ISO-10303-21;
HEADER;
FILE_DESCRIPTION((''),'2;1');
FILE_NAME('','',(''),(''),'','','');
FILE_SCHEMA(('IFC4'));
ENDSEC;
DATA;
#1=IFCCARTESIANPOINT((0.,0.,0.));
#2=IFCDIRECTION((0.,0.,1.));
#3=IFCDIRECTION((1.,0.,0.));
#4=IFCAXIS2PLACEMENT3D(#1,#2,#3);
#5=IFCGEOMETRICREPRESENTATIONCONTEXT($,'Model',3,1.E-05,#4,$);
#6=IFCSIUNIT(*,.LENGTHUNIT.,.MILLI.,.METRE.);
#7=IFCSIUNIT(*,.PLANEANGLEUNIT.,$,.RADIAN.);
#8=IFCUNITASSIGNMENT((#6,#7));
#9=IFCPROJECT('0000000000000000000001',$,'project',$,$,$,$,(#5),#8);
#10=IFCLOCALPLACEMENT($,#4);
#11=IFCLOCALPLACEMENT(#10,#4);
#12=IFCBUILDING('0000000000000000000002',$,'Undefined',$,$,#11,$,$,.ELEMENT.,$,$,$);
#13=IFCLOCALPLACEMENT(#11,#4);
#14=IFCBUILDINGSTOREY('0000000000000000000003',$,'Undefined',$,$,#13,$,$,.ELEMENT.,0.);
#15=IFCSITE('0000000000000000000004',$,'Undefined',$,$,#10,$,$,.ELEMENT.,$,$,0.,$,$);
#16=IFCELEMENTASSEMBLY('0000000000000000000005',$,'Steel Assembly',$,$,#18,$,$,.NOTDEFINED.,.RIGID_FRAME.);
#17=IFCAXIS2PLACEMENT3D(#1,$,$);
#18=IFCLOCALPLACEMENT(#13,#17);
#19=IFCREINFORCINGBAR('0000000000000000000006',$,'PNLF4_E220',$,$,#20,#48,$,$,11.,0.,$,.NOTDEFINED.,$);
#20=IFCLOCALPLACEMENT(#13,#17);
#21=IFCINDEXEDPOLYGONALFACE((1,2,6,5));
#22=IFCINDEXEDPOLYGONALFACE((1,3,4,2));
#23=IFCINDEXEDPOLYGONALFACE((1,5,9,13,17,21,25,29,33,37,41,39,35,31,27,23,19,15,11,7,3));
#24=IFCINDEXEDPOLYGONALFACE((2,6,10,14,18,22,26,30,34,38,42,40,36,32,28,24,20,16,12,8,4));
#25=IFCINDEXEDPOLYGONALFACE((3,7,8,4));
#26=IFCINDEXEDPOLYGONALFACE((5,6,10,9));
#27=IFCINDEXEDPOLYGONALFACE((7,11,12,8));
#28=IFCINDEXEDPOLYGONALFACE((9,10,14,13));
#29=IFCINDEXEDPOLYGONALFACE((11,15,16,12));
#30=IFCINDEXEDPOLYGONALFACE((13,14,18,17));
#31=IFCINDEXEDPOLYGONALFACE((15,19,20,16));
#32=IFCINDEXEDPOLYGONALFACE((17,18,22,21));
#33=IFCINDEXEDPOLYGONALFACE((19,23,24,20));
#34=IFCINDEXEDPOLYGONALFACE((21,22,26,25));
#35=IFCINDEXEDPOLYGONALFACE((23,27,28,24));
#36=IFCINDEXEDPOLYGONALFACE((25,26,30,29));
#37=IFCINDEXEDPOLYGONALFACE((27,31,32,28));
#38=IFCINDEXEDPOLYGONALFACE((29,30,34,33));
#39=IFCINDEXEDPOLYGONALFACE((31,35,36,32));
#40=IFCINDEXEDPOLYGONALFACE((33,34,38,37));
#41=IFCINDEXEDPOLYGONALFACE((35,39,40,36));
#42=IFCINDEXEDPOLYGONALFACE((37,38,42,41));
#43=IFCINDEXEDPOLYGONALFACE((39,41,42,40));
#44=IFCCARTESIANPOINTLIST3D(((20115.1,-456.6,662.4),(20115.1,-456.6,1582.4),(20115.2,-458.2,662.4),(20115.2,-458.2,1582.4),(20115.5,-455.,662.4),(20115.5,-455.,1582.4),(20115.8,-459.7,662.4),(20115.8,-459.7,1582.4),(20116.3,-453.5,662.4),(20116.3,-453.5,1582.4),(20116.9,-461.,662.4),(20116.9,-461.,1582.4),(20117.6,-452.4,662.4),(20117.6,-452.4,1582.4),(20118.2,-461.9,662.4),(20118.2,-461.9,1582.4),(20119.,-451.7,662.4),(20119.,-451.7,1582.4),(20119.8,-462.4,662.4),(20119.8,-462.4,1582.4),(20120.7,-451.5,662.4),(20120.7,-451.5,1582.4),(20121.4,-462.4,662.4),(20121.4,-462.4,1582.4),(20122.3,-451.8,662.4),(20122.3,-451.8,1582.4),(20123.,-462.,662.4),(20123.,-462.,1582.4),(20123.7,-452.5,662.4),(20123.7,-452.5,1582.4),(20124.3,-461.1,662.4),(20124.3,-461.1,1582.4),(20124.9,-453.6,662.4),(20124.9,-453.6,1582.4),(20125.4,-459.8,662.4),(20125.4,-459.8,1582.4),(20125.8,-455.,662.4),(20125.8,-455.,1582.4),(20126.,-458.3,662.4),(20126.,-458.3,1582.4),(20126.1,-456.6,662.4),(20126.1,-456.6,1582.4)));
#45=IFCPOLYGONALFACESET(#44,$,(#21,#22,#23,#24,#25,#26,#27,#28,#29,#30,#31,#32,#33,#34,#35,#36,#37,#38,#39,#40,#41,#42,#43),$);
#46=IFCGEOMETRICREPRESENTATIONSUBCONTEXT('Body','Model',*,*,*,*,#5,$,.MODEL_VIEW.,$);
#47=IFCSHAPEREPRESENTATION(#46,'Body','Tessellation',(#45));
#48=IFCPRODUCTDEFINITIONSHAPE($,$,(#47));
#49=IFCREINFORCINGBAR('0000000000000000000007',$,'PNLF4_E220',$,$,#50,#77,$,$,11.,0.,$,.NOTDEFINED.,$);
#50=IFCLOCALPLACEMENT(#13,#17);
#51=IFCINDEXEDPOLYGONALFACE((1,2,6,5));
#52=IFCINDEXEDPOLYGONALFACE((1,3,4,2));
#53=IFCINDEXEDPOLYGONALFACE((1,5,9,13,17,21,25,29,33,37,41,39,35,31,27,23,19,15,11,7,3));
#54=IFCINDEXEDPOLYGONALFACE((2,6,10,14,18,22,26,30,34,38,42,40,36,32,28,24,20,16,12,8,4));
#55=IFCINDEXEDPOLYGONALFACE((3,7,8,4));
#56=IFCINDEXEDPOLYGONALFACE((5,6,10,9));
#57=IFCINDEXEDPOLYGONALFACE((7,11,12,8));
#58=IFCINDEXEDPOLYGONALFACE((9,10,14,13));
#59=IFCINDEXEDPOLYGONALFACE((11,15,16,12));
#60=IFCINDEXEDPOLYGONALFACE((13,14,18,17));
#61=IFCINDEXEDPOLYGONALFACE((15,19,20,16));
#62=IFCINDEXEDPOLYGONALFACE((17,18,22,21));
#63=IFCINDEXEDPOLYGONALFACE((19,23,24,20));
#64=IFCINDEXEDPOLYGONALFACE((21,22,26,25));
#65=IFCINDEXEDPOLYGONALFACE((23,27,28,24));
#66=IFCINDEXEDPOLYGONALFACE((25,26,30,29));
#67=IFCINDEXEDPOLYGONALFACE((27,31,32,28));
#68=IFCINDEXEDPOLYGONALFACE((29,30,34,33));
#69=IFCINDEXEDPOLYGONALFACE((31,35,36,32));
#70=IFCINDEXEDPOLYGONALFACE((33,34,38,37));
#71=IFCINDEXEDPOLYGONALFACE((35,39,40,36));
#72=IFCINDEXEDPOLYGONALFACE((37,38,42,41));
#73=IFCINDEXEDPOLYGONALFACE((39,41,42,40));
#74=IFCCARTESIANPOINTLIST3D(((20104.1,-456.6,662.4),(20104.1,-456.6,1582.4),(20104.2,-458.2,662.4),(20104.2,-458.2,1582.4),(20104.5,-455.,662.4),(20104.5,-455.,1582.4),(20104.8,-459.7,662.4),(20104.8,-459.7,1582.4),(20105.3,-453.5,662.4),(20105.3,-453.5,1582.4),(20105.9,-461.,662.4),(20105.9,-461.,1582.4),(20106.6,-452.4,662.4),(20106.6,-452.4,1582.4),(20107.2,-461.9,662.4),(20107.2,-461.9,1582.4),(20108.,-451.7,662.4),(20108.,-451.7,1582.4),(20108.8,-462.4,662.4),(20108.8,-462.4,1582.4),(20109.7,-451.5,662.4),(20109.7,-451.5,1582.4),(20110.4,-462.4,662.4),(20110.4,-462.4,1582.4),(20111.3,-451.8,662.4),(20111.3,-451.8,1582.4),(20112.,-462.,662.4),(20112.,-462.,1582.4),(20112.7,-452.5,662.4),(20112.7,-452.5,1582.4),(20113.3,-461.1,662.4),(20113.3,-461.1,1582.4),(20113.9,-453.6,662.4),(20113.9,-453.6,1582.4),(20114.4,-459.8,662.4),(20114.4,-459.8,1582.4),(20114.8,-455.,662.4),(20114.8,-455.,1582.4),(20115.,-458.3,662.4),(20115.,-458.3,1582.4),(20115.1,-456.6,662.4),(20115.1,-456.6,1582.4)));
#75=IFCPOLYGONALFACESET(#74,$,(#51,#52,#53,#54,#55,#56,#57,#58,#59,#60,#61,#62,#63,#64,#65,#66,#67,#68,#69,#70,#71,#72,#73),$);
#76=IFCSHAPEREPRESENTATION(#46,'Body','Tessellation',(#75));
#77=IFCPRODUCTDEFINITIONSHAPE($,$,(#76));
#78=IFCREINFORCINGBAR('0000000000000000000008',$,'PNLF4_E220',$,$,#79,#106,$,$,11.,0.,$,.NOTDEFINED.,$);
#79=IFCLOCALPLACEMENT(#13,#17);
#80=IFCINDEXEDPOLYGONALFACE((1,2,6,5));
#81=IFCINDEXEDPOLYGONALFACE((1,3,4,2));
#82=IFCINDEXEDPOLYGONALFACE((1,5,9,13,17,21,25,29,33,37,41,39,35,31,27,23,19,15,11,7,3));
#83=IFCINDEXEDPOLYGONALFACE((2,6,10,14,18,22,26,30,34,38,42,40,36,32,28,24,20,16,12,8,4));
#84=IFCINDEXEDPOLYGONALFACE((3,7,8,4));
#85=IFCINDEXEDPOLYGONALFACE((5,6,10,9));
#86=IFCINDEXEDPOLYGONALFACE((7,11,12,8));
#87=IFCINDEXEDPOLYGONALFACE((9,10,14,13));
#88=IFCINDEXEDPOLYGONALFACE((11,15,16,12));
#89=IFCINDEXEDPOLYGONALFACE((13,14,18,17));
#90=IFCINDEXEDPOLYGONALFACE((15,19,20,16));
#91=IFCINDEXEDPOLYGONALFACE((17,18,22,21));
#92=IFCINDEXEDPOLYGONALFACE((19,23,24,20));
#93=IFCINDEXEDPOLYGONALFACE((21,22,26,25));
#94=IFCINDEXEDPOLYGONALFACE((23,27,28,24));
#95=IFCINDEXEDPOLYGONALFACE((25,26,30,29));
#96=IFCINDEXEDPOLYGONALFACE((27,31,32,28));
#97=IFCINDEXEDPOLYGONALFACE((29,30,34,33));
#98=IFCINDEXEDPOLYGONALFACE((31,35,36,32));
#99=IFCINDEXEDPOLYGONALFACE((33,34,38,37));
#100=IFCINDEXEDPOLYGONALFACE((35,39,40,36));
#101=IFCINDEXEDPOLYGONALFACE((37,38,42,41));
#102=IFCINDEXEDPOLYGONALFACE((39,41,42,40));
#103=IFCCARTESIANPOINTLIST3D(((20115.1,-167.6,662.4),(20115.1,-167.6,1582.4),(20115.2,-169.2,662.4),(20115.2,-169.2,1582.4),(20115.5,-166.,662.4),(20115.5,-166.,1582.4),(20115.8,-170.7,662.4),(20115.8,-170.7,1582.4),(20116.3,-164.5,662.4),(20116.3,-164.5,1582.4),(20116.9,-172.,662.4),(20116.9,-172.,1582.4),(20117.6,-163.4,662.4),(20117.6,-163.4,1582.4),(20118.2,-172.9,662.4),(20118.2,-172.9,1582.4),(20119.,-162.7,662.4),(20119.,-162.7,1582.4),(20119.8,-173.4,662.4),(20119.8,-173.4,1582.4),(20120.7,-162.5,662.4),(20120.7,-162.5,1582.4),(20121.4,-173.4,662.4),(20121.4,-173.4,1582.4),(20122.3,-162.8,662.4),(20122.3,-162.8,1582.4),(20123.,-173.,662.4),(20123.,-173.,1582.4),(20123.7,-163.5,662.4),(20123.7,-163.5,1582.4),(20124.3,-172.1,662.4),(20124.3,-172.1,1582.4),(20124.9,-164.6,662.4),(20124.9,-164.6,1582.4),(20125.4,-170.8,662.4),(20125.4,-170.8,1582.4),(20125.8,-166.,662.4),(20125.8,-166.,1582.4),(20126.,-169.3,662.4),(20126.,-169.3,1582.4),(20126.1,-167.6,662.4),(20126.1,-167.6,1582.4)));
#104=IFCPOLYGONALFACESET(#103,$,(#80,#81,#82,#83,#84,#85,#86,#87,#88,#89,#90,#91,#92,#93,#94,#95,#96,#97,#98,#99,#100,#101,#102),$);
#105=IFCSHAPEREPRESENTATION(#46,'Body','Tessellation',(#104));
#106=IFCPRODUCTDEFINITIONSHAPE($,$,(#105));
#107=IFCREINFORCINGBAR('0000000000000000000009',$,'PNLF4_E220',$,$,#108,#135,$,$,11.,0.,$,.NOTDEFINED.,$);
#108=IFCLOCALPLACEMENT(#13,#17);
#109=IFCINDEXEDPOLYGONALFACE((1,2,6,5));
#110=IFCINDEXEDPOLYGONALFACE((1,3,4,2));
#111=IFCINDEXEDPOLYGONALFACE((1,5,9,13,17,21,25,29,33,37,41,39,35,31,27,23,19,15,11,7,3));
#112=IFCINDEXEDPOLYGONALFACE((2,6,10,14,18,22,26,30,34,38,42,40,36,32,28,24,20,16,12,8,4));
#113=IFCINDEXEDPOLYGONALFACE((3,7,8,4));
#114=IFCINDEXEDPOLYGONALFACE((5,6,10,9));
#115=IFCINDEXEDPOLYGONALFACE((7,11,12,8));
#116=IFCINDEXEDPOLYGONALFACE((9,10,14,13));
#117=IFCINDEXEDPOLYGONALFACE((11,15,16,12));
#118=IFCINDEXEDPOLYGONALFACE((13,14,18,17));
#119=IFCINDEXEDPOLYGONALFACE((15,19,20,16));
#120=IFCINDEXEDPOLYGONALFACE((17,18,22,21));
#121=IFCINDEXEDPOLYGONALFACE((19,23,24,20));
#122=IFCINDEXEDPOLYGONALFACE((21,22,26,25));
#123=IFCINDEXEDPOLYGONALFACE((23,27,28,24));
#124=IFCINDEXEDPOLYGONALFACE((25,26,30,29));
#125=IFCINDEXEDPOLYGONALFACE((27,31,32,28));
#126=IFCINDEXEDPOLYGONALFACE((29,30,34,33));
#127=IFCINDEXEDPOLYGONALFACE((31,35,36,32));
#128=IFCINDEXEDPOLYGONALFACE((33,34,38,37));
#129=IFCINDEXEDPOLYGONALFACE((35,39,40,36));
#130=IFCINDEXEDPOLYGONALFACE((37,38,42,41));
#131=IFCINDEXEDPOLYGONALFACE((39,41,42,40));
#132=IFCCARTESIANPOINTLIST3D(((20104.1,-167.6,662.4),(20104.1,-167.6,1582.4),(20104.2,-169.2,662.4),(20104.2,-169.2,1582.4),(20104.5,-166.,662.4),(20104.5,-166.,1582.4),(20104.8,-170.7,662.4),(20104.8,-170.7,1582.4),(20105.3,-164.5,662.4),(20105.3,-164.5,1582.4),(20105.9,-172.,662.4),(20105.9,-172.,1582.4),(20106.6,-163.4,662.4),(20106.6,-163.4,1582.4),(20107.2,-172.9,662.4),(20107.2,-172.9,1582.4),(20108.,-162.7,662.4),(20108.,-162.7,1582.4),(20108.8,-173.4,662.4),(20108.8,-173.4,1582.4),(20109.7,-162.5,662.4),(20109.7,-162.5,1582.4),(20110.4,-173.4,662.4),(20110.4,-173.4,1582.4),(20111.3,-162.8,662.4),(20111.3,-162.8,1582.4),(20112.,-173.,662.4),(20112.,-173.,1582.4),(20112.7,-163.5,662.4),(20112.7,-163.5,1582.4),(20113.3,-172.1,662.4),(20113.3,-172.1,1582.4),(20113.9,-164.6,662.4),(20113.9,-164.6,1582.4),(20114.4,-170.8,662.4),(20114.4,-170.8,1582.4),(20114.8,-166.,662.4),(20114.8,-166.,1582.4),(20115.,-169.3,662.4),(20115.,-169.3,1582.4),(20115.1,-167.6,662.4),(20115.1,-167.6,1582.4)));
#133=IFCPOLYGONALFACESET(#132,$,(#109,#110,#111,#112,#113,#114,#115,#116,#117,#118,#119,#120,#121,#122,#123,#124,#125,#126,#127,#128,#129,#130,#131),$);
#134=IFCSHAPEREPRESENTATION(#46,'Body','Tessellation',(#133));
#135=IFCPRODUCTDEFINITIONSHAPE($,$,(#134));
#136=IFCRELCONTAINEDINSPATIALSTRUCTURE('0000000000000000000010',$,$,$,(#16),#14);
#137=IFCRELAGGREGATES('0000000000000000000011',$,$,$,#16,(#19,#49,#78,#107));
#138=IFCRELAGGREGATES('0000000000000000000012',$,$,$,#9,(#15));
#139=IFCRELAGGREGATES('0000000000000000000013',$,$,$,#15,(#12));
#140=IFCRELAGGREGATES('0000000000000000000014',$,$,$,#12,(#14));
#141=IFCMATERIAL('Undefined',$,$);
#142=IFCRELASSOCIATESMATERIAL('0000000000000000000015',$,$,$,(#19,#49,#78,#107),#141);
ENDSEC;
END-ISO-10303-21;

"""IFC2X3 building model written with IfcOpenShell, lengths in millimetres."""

from ifc_helpers import new_model, entity, si_unit, frame, origin_with_axes, place, context, subcontext, project, spatial, source, transform, mapped, material, element, aggregate, save


model = new_model("IFC2X3")

# Units and contexts
model_context = context("Model", 3, precision=1e-05, world=origin_with_axes())
body_context = subcontext(model_context, "Body", "Model", "MODEL_VIEW")
ifc_project = project(units=[si_unit("LENGTHUNIT", "METRE", prefix="MILLI"), si_unit("PLANEANGLEUNIT", "RADIAN")], contexts=[model_context])

# Site, building, storey
site_placement = place(None, origin_with_axes())
site = spatial("IfcSite", under=ifc_project, at=site_placement, Name="Undefined", CompositionType="ELEMENT", RefElevation=0.0)
building_placement = place(site_placement, origin_with_axes())
building = spatial("IfcBuilding", under=site, at=building_placement, Name="Undefined", CompositionType="ELEMENT")
storey_placement = place(building_placement, origin_with_axes())
storey = spatial("IfcBuildingStorey", under=building, at=storey_placement, Name="Undefined", CompositionType="ELEMENT", Elevation=0.0)

# Shared definitions
ifc_material_1 = material(Name="Undefined")

# Element assembly, reinforcing bars
assembly_1_placement = place(storey_placement, origin_with_axes())
assembly_1 = element("IfcElementAssembly", 1, at=assembly_1_placement, inside=storey, Name="Steel Assembly", AssemblyPlace="NOTDEFINED", PredefinedType="RIGID_FRAME")
shared_shape_1 = source(origin_with_axes(), body_context, "Body", "AdvancedSweptSolid", [
    entity("IfcSweptDiskSolid", entity("IfcTrimmedCurve", entity("IfcLine", entity("IfcCartesianPoint", [0.0, 0.0, 0.0]), entity("IfcVector", entity("IfcDirection", [1.0, 0.0, 0.0]), 1.0)), [entity("IfcParameterValue", 0.0)], [entity("IfcParameterValue", 920.0)], True, "PARAMETER"), 5.5, None, 0.0, 920.0),
])
reinforcing_bar_1_placement = place(assembly_1_placement, frame((20120.6, -457.0, 1582.4), z_axis=(0.006957, 0.999976, 0.0), x_axis=(0.0, 0.0, -1.0)))
reinforcing_bar_1 = element("IfcReinforcingBar", 2, at=reinforcing_bar_1_placement, material=ifc_material_1, Name="PNLF4_E220", BarRole="NOTDEFINED", CrossSectionArea=0.0, NominalDiameter=11.0, context=body_context, shape_type="MappedRepresentation", body=[
    mapped(shared_shape_1, transform((0.0, 0.0, 0.0))),
])
shared_shape_2 = source(origin_with_axes(), body_context, "Body", "AdvancedSweptSolid", [
    entity("IfcSweptDiskSolid", entity("IfcTrimmedCurve", entity("IfcLine", entity("IfcCartesianPoint", [0.0, 0.0, 0.0]), entity("IfcVector", entity("IfcDirection", [1.0, 0.0, 0.0]), 1.0)), [entity("IfcParameterValue", 0.0)], [entity("IfcParameterValue", 920.0)], True, "PARAMETER"), 5.5, None, 0.0, 920.0),
])
reinforcing_bar_2_placement = place(assembly_1_placement, frame((20109.6, -457.0, 1582.4), z_axis=(0.006957, 0.999976, 0.0), x_axis=(0.0, 0.0, -1.0)))
reinforcing_bar_2 = element("IfcReinforcingBar", 3, at=reinforcing_bar_2_placement, material=ifc_material_1, Name="PNLF4_E220", BarRole="NOTDEFINED", CrossSectionArea=0.0, NominalDiameter=11.0, context=body_context, shape_type="MappedRepresentation", body=[
    mapped(shared_shape_2, transform((0.0, 0.0, 0.0))),
])
shared_shape_3 = source(origin_with_axes(), body_context, "Body", "AdvancedSweptSolid", [
    entity("IfcSweptDiskSolid", entity("IfcTrimmedCurve", entity("IfcLine", entity("IfcCartesianPoint", [0.0, 0.0, 0.0]), entity("IfcVector", entity("IfcDirection", [1.0, 0.0, 0.0]), 1.0)), [entity("IfcParameterValue", 0.0)], [entity("IfcParameterValue", 920.0)], True, "PARAMETER"), 5.5, None, 0.0, 920.0),
])
reinforcing_bar_3_placement = place(assembly_1_placement, frame((20120.6, -168.0, 1582.4), z_axis=(0.006957, 0.999976, 0.0), x_axis=(0.0, 0.0, -1.0)))
reinforcing_bar_3 = element("IfcReinforcingBar", 4, at=reinforcing_bar_3_placement, material=ifc_material_1, Name="PNLF4_E220", BarRole="NOTDEFINED", CrossSectionArea=0.0, NominalDiameter=11.0, context=body_context, shape_type="MappedRepresentation", body=[
    mapped(shared_shape_3, transform((0.0, 0.0, 0.0))),
])
shared_shape_4 = source(origin_with_axes(), body_context, "Body", "AdvancedSweptSolid", [
    entity("IfcSweptDiskSolid", entity("IfcTrimmedCurve", entity("IfcLine", entity("IfcCartesianPoint", [0.0, 0.0, 0.0]), entity("IfcVector", entity("IfcDirection", [1.0, 0.0, 0.0]), 1.0)), [entity("IfcParameterValue", 0.0)], [entity("IfcParameterValue", 920.0)], True, "PARAMETER"), 5.5, None, 0.0, 920.0),
])
reinforcing_bar_4_placement = place(assembly_1_placement, frame((20109.6, -168.0, 1582.4), z_axis=(0.006957, 0.999976, 0.0), x_axis=(0.0, 0.0, -1.0)))
reinforcing_bar_4 = element("IfcReinforcingBar", 5, at=reinforcing_bar_4_placement, material=ifc_material_1, Name="PNLF4_E220", BarRole="NOTDEFINED", CrossSectionArea=0.0, NominalDiameter=11.0, context=body_context, shape_type="MappedRepresentation", body=[
    mapped(shared_shape_4, transform((0.0, 0.0, 0.0))),
])
aggregate(assembly_1, [reinforcing_bar_1, reinforcing_bar_2, reinforcing_bar_3, reinforcing_bar_4])

save(model, "model.ifc")
